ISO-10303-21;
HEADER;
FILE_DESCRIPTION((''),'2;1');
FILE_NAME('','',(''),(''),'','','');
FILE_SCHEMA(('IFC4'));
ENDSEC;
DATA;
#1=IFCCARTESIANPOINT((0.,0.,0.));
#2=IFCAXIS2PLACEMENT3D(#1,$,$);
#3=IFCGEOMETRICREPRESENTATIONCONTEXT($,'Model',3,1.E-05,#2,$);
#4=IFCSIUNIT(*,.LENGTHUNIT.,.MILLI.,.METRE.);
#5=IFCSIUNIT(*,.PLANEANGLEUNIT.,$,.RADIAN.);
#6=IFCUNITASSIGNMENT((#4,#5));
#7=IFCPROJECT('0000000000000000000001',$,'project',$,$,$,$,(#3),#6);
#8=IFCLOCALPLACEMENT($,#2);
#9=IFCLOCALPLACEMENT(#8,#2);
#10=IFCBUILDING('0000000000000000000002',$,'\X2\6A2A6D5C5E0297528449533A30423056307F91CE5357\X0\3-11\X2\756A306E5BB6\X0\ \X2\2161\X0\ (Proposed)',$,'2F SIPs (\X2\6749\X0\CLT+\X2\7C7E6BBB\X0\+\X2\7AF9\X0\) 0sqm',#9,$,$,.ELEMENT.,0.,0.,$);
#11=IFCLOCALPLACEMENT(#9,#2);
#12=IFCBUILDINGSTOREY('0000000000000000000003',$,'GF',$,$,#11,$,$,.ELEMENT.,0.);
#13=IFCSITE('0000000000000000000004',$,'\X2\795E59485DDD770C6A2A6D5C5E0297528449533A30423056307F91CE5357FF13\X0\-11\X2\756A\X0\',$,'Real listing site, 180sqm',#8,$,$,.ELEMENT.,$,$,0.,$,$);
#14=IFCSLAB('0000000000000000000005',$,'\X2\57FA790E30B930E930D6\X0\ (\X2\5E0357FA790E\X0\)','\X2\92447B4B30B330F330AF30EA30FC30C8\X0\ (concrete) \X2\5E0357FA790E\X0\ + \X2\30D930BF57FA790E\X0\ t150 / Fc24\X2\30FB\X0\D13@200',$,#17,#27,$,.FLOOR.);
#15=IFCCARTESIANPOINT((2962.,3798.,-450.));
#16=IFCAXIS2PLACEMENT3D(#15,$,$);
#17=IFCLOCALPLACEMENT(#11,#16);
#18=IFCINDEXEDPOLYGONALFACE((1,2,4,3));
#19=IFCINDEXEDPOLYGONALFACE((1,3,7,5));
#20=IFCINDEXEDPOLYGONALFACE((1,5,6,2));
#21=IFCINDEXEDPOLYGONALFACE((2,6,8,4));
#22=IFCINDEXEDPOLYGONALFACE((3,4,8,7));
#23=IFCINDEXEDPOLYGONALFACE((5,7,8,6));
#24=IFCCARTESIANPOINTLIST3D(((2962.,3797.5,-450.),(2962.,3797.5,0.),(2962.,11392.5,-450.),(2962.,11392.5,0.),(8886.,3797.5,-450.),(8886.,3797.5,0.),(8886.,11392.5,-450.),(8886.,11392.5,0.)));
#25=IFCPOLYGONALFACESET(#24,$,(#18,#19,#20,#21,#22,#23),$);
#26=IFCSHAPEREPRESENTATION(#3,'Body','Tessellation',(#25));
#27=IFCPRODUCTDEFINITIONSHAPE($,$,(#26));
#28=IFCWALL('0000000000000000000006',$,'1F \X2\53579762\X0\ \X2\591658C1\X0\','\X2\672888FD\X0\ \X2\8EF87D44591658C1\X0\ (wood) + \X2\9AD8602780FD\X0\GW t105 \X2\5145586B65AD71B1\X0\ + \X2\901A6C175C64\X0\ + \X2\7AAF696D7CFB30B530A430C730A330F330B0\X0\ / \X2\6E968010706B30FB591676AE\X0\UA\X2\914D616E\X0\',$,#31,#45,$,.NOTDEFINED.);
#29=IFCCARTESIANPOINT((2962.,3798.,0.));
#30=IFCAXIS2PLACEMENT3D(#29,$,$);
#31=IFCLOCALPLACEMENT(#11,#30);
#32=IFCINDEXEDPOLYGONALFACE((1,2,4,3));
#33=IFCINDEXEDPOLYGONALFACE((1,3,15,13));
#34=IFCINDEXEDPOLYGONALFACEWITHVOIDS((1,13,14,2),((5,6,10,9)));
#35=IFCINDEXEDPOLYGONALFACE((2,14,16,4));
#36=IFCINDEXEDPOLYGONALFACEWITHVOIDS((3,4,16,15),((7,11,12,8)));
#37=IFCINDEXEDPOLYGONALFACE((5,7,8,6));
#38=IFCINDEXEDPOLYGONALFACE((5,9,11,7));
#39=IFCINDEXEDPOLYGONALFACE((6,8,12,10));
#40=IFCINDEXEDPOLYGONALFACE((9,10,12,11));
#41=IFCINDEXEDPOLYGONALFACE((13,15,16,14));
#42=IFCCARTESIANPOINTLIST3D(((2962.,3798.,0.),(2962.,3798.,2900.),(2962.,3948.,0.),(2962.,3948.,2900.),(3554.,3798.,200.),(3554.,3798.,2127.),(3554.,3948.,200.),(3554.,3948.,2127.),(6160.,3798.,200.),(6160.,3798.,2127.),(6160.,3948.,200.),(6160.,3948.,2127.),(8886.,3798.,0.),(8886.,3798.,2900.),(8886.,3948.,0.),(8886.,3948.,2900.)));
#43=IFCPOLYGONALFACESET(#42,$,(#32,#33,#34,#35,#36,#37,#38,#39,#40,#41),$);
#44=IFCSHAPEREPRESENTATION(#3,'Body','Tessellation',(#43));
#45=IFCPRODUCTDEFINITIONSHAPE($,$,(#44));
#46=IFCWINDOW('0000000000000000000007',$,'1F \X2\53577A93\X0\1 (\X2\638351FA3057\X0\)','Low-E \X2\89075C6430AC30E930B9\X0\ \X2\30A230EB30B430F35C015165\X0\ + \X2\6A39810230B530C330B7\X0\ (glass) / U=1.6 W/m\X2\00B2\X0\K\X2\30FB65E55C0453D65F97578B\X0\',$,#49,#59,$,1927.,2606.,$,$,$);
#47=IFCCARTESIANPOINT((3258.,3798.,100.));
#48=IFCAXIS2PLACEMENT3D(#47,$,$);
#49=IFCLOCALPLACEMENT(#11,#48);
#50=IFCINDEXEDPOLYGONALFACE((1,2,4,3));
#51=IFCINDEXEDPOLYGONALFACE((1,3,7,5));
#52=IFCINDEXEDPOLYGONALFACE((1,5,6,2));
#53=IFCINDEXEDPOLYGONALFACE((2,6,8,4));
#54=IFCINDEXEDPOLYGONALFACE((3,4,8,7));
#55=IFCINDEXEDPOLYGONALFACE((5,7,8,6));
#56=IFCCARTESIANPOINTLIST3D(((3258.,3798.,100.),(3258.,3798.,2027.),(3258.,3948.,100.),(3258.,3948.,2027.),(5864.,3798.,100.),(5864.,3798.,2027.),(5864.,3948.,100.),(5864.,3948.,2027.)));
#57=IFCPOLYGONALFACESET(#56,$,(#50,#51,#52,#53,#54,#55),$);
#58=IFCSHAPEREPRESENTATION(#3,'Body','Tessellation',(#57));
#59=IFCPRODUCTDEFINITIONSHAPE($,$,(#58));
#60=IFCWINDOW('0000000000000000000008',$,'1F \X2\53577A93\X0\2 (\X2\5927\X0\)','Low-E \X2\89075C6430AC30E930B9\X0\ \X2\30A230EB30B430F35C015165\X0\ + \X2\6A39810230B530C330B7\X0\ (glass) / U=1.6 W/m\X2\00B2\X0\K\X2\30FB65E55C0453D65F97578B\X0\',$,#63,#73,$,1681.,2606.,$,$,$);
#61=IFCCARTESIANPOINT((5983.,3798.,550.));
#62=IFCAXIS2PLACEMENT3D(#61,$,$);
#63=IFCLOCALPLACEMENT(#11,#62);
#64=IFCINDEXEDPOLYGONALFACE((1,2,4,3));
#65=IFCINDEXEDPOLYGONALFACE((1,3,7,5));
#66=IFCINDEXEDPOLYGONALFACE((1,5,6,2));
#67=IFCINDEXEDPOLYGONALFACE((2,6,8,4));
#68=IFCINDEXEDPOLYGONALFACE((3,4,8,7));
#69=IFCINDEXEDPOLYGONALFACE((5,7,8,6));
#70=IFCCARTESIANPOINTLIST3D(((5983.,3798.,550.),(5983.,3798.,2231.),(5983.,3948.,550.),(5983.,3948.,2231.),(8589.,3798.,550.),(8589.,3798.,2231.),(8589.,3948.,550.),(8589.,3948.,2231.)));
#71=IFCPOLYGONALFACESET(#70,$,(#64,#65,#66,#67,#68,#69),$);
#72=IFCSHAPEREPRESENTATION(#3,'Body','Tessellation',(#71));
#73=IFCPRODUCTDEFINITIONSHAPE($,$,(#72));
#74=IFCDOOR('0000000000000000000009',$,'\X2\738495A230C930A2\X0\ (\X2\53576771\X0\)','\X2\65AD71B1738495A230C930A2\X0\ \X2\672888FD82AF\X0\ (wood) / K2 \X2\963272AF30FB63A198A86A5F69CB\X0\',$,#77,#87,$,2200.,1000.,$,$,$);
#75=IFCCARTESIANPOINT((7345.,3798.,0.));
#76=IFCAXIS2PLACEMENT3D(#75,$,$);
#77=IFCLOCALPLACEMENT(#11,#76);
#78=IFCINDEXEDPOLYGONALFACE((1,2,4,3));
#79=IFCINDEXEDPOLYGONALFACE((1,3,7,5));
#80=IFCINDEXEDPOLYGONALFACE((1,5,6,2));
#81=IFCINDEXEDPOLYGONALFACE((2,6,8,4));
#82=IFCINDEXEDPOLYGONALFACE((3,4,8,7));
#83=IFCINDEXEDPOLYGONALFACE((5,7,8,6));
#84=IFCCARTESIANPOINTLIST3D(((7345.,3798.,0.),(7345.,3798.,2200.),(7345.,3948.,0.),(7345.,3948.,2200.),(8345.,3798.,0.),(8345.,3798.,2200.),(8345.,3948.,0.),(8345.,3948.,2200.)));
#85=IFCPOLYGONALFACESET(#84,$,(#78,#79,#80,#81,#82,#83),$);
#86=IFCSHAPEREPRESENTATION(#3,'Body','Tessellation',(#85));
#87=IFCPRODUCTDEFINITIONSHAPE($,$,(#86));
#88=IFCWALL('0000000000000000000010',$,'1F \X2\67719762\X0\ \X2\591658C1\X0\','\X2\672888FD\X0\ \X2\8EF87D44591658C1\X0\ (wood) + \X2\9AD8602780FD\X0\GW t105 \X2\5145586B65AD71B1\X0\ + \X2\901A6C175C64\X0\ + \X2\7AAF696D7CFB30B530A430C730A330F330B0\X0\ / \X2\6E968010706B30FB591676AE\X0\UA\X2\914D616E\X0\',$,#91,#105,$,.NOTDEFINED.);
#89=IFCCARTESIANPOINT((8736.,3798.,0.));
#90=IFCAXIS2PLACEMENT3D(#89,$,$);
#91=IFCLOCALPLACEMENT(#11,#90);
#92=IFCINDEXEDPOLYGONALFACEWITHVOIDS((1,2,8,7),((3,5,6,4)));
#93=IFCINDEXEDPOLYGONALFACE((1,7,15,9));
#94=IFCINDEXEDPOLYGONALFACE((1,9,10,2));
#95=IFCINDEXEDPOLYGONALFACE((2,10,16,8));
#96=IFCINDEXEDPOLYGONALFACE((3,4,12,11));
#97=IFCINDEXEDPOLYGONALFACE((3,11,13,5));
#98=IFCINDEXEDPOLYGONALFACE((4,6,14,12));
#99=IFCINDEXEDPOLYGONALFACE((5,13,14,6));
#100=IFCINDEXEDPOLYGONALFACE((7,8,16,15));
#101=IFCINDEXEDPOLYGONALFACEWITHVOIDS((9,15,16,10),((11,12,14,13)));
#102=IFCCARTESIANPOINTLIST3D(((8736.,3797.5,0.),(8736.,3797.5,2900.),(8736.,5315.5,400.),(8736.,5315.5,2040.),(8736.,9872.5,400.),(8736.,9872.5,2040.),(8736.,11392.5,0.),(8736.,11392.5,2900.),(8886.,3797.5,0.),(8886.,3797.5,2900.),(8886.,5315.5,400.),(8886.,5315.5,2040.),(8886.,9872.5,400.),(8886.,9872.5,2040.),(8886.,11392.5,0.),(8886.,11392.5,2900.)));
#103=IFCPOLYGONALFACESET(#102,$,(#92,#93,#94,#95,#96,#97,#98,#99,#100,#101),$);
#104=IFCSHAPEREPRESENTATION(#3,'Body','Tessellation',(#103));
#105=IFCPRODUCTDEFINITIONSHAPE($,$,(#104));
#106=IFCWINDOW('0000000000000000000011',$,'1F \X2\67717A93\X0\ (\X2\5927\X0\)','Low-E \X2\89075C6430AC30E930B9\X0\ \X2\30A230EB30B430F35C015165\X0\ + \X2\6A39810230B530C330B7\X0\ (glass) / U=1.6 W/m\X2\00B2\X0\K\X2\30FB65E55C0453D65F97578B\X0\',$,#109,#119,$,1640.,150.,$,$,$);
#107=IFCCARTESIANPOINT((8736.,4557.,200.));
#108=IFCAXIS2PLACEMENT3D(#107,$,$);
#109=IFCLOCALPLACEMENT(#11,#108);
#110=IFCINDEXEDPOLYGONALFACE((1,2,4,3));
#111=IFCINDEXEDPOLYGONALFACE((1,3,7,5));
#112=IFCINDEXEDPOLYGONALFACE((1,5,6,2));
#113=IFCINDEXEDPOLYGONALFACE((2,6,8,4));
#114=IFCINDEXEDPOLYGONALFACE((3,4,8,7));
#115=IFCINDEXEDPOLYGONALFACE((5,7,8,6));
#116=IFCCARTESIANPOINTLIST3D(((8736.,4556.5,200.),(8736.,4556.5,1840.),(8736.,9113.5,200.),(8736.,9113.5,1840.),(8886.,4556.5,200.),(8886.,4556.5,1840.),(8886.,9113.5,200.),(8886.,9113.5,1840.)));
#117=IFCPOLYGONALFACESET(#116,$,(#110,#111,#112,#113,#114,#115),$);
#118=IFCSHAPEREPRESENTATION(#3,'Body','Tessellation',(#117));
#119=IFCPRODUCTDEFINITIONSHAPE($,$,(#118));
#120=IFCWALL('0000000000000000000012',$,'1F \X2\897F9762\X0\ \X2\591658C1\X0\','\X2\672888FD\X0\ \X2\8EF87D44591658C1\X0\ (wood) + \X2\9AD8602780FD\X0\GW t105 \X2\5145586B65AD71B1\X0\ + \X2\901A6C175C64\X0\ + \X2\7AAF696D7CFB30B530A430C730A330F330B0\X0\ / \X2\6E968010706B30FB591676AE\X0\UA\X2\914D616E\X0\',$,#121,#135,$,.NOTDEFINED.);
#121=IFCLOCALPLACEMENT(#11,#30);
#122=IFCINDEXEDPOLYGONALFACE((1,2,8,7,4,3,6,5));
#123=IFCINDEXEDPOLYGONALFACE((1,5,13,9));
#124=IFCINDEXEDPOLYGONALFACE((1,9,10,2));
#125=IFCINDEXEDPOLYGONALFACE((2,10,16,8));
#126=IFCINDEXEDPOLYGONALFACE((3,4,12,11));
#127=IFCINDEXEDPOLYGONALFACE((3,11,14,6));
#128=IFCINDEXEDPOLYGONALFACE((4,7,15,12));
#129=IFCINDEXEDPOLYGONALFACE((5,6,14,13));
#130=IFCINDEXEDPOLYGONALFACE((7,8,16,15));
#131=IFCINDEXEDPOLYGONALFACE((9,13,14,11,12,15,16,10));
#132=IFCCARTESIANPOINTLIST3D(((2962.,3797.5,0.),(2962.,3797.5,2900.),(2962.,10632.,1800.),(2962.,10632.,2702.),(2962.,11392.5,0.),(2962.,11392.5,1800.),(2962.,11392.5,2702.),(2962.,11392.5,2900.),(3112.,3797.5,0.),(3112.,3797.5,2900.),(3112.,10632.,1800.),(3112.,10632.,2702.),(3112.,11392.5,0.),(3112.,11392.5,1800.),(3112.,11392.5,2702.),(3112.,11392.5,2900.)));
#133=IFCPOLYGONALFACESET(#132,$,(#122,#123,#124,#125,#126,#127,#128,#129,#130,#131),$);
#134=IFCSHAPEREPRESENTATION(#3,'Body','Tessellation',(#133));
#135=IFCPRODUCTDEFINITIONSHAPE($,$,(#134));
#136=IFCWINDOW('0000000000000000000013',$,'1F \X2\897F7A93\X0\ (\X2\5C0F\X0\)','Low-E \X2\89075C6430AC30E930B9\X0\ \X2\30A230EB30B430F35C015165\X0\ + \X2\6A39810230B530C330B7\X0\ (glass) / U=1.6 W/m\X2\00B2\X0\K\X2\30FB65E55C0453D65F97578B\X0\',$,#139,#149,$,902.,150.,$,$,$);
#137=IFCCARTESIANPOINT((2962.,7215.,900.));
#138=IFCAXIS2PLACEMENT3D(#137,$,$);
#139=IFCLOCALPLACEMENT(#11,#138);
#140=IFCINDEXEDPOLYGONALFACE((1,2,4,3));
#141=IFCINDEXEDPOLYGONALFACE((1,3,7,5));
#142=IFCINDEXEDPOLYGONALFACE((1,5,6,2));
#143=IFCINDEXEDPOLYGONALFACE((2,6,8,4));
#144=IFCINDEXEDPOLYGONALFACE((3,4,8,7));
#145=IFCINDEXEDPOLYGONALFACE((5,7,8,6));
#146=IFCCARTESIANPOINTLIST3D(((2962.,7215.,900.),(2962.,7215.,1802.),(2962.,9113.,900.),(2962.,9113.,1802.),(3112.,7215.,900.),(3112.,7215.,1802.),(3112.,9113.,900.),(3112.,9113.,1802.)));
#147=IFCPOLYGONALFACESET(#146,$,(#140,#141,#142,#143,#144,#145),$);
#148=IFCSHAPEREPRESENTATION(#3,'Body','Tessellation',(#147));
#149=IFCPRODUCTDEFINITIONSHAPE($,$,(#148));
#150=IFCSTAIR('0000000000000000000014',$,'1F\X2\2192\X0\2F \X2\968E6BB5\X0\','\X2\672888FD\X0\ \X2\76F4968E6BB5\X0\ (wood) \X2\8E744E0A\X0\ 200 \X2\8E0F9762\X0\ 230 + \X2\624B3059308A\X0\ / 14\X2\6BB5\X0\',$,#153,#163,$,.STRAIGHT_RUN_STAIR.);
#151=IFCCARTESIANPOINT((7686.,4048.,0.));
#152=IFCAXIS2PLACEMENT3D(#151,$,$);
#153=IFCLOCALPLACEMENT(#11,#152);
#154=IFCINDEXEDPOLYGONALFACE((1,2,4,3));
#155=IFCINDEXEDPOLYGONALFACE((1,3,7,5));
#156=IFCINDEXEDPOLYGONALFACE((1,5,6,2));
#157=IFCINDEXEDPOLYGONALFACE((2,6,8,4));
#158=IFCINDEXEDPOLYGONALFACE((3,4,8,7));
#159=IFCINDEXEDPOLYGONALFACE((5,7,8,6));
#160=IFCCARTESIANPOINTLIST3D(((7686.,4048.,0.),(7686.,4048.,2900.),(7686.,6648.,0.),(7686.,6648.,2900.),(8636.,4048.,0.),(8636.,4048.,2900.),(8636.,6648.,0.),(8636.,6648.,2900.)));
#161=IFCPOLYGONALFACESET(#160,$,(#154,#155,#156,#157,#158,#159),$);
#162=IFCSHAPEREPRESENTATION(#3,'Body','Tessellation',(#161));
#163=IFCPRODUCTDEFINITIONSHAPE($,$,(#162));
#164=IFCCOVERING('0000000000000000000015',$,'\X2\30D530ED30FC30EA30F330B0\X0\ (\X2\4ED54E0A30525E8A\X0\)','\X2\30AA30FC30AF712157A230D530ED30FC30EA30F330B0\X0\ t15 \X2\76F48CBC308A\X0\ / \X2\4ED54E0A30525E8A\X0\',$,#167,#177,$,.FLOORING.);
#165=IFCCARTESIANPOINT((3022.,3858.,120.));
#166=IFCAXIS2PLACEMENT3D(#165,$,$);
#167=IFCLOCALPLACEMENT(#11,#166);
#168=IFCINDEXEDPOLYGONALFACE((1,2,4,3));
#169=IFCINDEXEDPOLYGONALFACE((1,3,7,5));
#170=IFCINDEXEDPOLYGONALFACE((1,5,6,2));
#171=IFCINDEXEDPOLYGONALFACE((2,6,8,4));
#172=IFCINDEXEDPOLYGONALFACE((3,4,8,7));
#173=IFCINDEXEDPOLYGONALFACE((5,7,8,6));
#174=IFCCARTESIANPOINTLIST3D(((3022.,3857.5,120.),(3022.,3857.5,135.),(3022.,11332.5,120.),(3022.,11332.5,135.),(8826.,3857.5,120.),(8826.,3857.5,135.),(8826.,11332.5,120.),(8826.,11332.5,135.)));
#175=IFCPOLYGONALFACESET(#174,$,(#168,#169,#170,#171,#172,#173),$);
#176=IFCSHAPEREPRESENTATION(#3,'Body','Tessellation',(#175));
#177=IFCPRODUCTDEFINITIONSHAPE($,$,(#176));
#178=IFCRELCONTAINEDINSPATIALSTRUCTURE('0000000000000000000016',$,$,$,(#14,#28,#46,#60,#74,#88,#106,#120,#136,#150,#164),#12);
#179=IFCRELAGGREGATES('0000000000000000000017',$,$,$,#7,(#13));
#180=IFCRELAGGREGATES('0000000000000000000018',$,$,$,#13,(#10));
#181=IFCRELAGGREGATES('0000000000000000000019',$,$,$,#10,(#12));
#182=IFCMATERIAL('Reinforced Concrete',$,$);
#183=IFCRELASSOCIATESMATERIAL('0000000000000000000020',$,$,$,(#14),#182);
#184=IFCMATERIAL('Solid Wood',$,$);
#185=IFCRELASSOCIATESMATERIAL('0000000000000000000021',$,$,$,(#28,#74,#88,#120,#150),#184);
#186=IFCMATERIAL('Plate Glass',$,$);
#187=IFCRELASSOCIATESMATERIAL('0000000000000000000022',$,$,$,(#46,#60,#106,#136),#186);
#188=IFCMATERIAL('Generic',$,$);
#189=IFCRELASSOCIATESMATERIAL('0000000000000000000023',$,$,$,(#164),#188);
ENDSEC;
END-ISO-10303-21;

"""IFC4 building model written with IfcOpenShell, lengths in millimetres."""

from ifc_helpers import new_model, si_unit, frame, frame_2d, origin, place, context, project, spatial, rectangle, extrude, material, element, fill, save


model = new_model("IFC4")

# Units and contexts
model_context = context("Model", 3, precision=1e-05, world=origin())
ifc_project = project(units=[si_unit("LENGTHUNIT", "METRE", prefix="MILLI"), si_unit("PLANEANGLEUNIT", "RADIAN")], contexts=[model_context])

# Site, building, storey
site_placement = place(None, origin())
site = spatial("IfcSite", under=ifc_project, at=site_placement, Name="神奈川県横浜市青葉区あざみ野南３-11番", ObjectType="Real listing site, 180sqm", CompositionType="ELEMENT", RefElevation=0.0)
building_placement = place(site_placement, origin())
building = spatial("IfcBuilding", under=site, at=building_placement, Name="横浜市青葉区あざみ野南3-11番の家 Ⅱ (Proposed)", ObjectType="2F SIPs (杉CLT+籾殻+竹) 0sqm", CompositionType="ELEMENT", ElevationOfRefHeight=0.0, ElevationOfTerrain=0.0)
storey_placement = place(building_placement, origin())
storey = spatial("IfcBuildingStorey", under=building, at=storey_placement, Name="GF", CompositionType="ELEMENT", Elevation=0.0)

# Slab
ifc_material_1 = material(Name="Reinforced Concrete")
slab_1_placement = place(storey_placement, frame((2962.0, 3798.0, -450.0)))
element("IfcSlab", 1, at=slab_1_placement, inside=storey, material=ifc_material_1, Name="基礎スラブ (布基礎)", Description="鉄筋コンクリート (concrete) 布基礎 + ベタ基礎 t150 / Fc24・D13@200", PredefinedType="FLOOR", context=model_context, shape_type="SweptSolid", body=[
    extrude(rectangle(XDim=5924.0, YDim=7595.0, at=frame_2d((2962.0, 3797.0))), frame((2962.0, 3798.0, -450.0)), (0.0, 0.0, 1.0), 450.0),
])
ifc_material_2 = material(Name="Solid Wood")

# Wall, openings, windows, door
wall_1_placement = place(storey_placement, frame((2962.0, 3798.0, 0.0)))
wall_1 = element("IfcWall", 2, at=wall_1_placement, inside=storey, material=ifc_material_2, Name="1F 南面 外壁", Description="木製 軸組外壁 (wood) + 高性能GW t105 充填断熱 + 通気層 + 窯業系サイディング / 準耐火・外皮UA配慮", PredefinedType="NOTDEFINED", context=model_context, shape_type="SweptSolid", body=[
    extrude(rectangle(XDim=5924.0, YDim=150.0, at=frame_2d((2962.0, 75.0))), frame((2962.0, 3798.0, 0.0)), (0.0, 0.0, 1.0), 2900.0),
])
opening_1_placement = place(storey_placement, frame((3258.0, 3798.0, 100.0)))
opening_1 = element("IfcOpeningElement", 3, at=opening_1_placement, cuts=wall_1, PredefinedType="NOTDEFINED", context=model_context, shape_type="SweptSolid", body=[
    extrude(rectangle(XDim=2606.0, YDim=150.0, at=frame_2d((1303.0, 75.0))), frame((3258.0, 3798.0, 100.0)), (0.0, 0.0, 1.0), 1927.0),
])
opening_2_placement = place(storey_placement, frame((5983.0, 3798.0, 550.0)))
opening_2 = element("IfcOpeningElement", 4, at=opening_2_placement, cuts=wall_1, PredefinedType="NOTDEFINED", context=model_context, shape_type="SweptSolid", body=[
    extrude(rectangle(XDim=2606.0, YDim=150.0, at=frame_2d((1303.0, 75.0))), frame((5983.0, 3798.0, 550.0)), (0.0, 0.0, 1.0), 1681.0),
])
opening_3_placement = place(storey_placement, frame((7345.0, 3798.0, 0.0)))
opening_3 = element("IfcOpeningElement", 5, at=opening_3_placement, cuts=wall_1, PredefinedType="NOTDEFINED", context=model_context, shape_type="SweptSolid", body=[
    extrude(rectangle(XDim=1000.0, YDim=150.0, at=frame_2d((500.0, 75.0))), frame((7345.0, 3798.0, 0.0)), (0.0, 0.0, 1.0), 2200.0),
])
ifc_material_3 = material(Name="Plate Glass")
window_1_placement = place(storey_placement, frame((3258.0, 3798.0, 100.0)))
window_1 = element("IfcWindow", 6, at=window_1_placement, inside=storey, material=ifc_material_3, Name="1F 南窓1 (掃出し)", Description="Low-E 複層ガラス アルゴン封入 + 樹脂サッシ (glass) / U=1.6 W/m²K・日射取得型", OverallHeight=1927.0, OverallWidth=2606.0, context=model_context, shape_type="SweptSolid", body=[
    extrude(rectangle(XDim=2606.0, YDim=150.0, at=frame_2d((1303.0, 75.0))), frame((3258.0, 3798.0, 100.0)), (0.0, 0.0, 1.0), 1927.0),
])
fill(opening_1, window_1)
window_2_placement = place(storey_placement, frame((5983.0, 3798.0, 550.0)))
window_2 = element("IfcWindow", 7, at=window_2_placement, inside=storey, material=ifc_material_3, Name="1F 南窓2 (大)", Description="Low-E 複層ガラス アルゴン封入 + 樹脂サッシ (glass) / U=1.6 W/m²K・日射取得型", OverallHeight=1681.0, OverallWidth=2606.0, context=model_context, shape_type="SweptSolid", body=[
    extrude(rectangle(XDim=2606.0, YDim=150.0, at=frame_2d((1303.0, 75.0))), frame((5983.0, 3798.0, 550.0)), (0.0, 0.0, 1.0), 1681.0),
])
fill(opening_2, window_2)
door_placement = place(storey_placement, frame((7345.0, 3798.0, 0.0)))
door = element("IfcDoor", 8, at=door_placement, inside=storey, material=ifc_material_2, Name="玄関ドア (南東)", Description="断熱玄関ドア 木製芯 (wood) / K2 防犯・採風機構", OverallHeight=2200.0, OverallWidth=1000.0, context=model_context, shape_type="SweptSolid", body=[
    extrude(rectangle(XDim=1000.0, YDim=150.0, at=frame_2d((500.0, 75.0))), frame((7345.0, 3798.0, 0.0)), (0.0, 0.0, 1.0), 2200.0),
])
fill(opening_3, door)

# Walls, openings, windows
wall_2_placement = place(storey_placement, frame((8736.0, 3798.0, 0.0)))
wall_2 = element("IfcWall", 9, at=wall_2_placement, inside=storey, material=ifc_material_2, Name="1F 東面 外壁", Description="木製 軸組外壁 (wood) + 高性能GW t105 充填断熱 + 通気層 + 窯業系サイディング / 準耐火・外皮UA配慮", PredefinedType="NOTDEFINED", context=model_context, shape_type="SweptSolid", body=[
    extrude(rectangle(XDim=150.0, YDim=7595.0, at=frame_2d((75.0, 3797.0))), frame((8736.0, 3798.0, 0.0)), (0.0, 0.0, 1.0), 2900.0),
])
opening_4_placement = place(storey_placement, frame((8736.0, 4557.0, 200.0)))
opening_4 = element("IfcOpeningElement", 10, at=opening_4_placement, cuts=wall_2, PredefinedType="NOTDEFINED", context=model_context, shape_type="SweptSolid", body=[
    extrude(rectangle(XDim=150.0, YDim=4557.0, at=frame_2d((75.0, 2278.0))), frame((8736.0, 4557.0, 200.0)), (0.0, 0.0, 1.0), 1640.0),
])
window_3_placement = place(storey_placement, frame((8736.0, 4557.0, 200.0)))
window_3 = element("IfcWindow", 11, at=window_3_placement, inside=storey, material=ifc_material_3, Name="1F 東窓 (大)", Description="Low-E 複層ガラス アルゴン封入 + 樹脂サッシ (glass) / U=1.6 W/m²K・日射取得型", OverallHeight=1640.0, OverallWidth=150.0, context=model_context, shape_type="SweptSolid", body=[
    extrude(rectangle(XDim=150.0, YDim=4557.0, at=frame_2d((75.0, 2278.0))), frame((8736.0, 4557.0, 200.0)), (0.0, 0.0, 1.0), 1640.0),
])
fill(opening_4, window_3)
wall_3_placement = place(storey_placement, frame((2962.0, 3798.0, 0.0)))
wall_3 = element("IfcWall", 12, at=wall_3_placement, inside=storey, material=ifc_material_2, Name="1F 西面 外壁", Description="木製 軸組外壁 (wood) + 高性能GW t105 充填断熱 + 通気層 + 窯業系サイディング / 準耐火・外皮UA配慮", PredefinedType="NOTDEFINED", context=model_context, shape_type="SweptSolid", body=[
    extrude(rectangle(XDim=150.0, YDim=7595.0, at=frame_2d((75.0, 3797.0))), frame((2962.0, 3798.0, 0.0)), (0.0, 0.0, 1.0), 2900.0),
])
opening_5_placement = place(storey_placement, frame((2962.0, 7215.0, 900.0)))
opening_5 = element("IfcOpeningElement", 13, at=opening_5_placement, cuts=wall_3, PredefinedType="NOTDEFINED", context=model_context, shape_type="SweptSolid", body=[
    extrude(rectangle(XDim=150.0, YDim=1898.0, at=frame_2d((75.0, 949.0))), frame((2962.0, 7215.0, 900.0)), (0.0, 0.0, 1.0), 902.0),
])
window_4_placement = place(storey_placement, frame((2962.0, 7215.0, 900.0)))
window_4 = element("IfcWindow", 14, at=window_4_placement, inside=storey, material=ifc_material_3, Name="1F 西窓 (小)", Description="Low-E 複層ガラス アルゴン封入 + 樹脂サッシ (glass) / U=1.6 W/m²K・日射取得型", OverallHeight=902.0, OverallWidth=150.0, context=model_context, shape_type="SweptSolid", body=[
    extrude(rectangle(XDim=150.0, YDim=1898.0, at=frame_2d((75.0, 949.0))), frame((2962.0, 7215.0, 900.0)), (0.0, 0.0, 1.0), 902.0),
])
fill(opening_5, window_4)

# Stair
stair_placement = place(storey_placement, frame((7686.0, 4048.0, 0.0)))
element("IfcStair", 15, at=stair_placement, inside=storey, material=ifc_material_2, Name="1F→2F 階段", Description="木製 直階段 (wood) 蹴上 200 踏面 230 + 手すり / 14段", PredefinedType="STRAIGHT_RUN_STAIR", context=model_context, shape_type="SweptSolid", body=[
    extrude(rectangle(XDim=950.0, YDim=2600.0, at=frame_2d((475.0, 1300.0))), frame((7686.0, 4048.0, 0.0)), (0.0, 0.0, 1.0), 2900.0),
])

# Covering
ifc_material_4 = material(Name="Generic")
covering_placement = place(storey_placement, frame((3022.0, 3858.0, 120.0)))
element("IfcCovering", 16, at=covering_placement, inside=storey, material=ifc_material_4, Name="フローリング (仕上げ床)", Description="オーク無垢フローリング t15 直貼り / 仕上げ床", PredefinedType="FLOORING", context=model_context, shape_type="SweptSolid", body=[
    extrude(rectangle(XDim=5804.0, YDim=7475.0, at=frame_2d((2902.0, 3737.0))), frame((3022.0, 3858.0, 120.0)), (0.0, 0.0, 1.0), 15.0),
])

save(model, "model.ifc")
